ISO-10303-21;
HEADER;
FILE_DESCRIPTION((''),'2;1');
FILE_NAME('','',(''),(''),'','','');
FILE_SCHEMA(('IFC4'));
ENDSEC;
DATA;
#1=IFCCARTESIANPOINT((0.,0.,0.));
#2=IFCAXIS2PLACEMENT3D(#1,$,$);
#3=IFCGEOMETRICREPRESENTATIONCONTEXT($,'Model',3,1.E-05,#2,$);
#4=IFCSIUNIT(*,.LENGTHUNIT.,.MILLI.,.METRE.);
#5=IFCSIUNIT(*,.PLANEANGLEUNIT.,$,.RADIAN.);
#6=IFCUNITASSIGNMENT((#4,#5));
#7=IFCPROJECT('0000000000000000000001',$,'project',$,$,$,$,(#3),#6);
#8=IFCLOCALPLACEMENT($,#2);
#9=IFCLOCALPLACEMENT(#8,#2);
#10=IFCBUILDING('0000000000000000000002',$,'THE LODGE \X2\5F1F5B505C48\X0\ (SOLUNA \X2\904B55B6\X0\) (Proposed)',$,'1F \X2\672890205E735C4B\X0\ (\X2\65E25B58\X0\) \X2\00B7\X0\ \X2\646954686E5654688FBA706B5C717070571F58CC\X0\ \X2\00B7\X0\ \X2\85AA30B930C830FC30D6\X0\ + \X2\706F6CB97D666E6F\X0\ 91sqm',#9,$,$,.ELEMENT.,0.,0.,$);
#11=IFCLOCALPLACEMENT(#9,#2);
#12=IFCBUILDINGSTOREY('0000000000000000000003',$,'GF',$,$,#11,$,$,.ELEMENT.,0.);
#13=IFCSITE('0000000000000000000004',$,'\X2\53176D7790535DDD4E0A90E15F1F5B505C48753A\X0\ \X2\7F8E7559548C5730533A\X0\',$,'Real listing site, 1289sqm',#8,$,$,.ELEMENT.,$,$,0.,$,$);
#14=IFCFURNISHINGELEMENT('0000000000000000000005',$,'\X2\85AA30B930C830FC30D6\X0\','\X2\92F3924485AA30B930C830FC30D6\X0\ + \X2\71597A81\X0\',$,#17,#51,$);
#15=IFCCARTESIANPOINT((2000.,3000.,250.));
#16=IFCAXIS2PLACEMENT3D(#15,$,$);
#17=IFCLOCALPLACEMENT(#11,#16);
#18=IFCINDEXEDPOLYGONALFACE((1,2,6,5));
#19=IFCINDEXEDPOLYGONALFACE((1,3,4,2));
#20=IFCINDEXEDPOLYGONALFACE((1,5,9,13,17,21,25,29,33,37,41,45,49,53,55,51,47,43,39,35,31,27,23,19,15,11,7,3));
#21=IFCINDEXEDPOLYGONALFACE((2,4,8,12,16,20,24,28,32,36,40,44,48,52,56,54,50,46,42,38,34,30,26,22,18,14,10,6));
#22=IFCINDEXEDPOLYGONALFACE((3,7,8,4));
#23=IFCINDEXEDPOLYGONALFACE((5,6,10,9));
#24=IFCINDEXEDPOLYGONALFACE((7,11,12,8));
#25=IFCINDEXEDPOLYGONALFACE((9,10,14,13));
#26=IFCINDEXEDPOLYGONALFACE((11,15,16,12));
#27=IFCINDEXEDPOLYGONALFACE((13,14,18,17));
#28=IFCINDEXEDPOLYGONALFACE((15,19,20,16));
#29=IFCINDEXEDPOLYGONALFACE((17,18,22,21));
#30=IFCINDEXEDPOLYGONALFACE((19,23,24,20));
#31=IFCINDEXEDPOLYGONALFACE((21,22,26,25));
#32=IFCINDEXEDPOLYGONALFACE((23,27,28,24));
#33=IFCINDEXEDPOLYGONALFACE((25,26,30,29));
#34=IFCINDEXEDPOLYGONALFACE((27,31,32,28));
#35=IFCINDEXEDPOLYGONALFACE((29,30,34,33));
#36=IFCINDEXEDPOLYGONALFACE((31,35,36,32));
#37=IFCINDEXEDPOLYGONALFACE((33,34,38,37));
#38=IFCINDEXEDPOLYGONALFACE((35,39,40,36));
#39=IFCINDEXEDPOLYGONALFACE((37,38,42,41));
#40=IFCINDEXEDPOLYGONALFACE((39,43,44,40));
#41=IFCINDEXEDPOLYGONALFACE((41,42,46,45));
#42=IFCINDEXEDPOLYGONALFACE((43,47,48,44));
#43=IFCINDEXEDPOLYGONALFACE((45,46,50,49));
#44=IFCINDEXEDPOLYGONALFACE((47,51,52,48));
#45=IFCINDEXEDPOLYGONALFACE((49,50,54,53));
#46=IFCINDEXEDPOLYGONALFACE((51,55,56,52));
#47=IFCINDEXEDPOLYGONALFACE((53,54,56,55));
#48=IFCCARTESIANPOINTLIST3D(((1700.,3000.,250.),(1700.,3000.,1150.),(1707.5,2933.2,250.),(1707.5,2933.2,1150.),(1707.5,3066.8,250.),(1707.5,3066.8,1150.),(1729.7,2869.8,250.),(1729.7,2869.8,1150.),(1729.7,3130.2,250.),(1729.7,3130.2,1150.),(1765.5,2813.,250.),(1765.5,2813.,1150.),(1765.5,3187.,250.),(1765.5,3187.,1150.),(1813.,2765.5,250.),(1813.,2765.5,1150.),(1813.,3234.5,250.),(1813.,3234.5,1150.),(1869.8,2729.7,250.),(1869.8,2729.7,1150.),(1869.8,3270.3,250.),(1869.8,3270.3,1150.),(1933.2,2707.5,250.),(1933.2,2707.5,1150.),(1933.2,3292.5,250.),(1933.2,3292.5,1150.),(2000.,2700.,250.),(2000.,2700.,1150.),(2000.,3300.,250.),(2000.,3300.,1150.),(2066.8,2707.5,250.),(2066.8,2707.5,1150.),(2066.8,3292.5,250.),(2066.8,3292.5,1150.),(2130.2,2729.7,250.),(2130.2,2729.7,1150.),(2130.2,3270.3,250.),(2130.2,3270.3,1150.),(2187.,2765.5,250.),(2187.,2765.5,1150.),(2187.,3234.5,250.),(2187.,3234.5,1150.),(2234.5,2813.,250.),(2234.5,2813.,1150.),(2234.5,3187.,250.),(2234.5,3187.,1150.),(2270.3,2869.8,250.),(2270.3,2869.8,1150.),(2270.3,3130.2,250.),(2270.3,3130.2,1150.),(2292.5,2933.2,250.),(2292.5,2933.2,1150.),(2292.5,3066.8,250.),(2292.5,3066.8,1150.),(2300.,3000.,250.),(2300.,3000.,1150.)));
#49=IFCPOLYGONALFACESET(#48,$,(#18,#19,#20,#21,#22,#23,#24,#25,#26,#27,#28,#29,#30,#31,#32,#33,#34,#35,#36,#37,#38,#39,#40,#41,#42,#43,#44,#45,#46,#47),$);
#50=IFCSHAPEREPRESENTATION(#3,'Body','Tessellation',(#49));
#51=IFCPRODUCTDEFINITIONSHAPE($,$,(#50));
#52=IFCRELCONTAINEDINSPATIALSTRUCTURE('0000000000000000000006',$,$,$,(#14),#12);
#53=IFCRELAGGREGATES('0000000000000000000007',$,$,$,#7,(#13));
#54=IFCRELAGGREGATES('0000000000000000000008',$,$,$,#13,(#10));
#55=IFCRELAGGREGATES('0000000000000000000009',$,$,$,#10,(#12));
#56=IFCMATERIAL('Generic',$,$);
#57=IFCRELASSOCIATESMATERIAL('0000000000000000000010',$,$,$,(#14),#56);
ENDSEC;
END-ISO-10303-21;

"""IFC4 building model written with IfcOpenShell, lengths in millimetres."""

from ifc_helpers import new_model, si_unit, frame, origin, origin_2d, place, context, project, spatial, circle, extrude, material, element, save


model = new_model("IFC4")

# Units and contexts
model_context = context("Model", 3, precision=1e-05, world=origin())
ifc_project = project(units=[si_unit("LENGTHUNIT", "METRE", prefix="MILLI"), si_unit("PLANEANGLEUNIT", "RADIAN")], contexts=[model_context])

# Site, building, storey
site_placement = place(None, origin())
site = spatial("IfcSite", under=ifc_project, at=site_placement, Name="北海道川上郡弟子屈町 美留和地区", ObjectType="Real listing site, 1289sqm", CompositionType="ELEMENT", RefElevation=0.0)
building_placement = place(site_placement, origin())
building = spatial("IfcBuilding", under=site, at=building_placement, Name="THE LODGE 弟子屈 (SOLUNA 運営) (Proposed)", ObjectType="1F 木造平屋 (既存) · 摩周湖周辺火山灰土壌 · 薪ストーブ + 灯油給湯 91sqm", CompositionType="ELEMENT", ElevationOfRefHeight=0.0, ElevationOfTerrain=0.0)
storey_placement = place(building_placement, origin())
storey = spatial("IfcBuildingStorey", under=building, at=storey_placement, Name="GF", CompositionType="ELEMENT", Elevation=0.0)

# Shared definitions
ifc_material_1 = material(Name="Generic")

# Furnishing element
furnishing_placement = place(storey_placement, frame((2000.0, 3000.0, 250.0)))
element("IfcFurnishingElement", 1, at=furnishing_placement, inside=storey, material=ifc_material_1, Name="薪ストーブ", Description="鋳鉄薪ストーブ + 煙突", context=model_context, shape_type="SweptSolid", body=[
    extrude(circle(Radius=300.0, at=origin_2d()), frame((2000.0, 3000.0, 250.0)), (0.0, 0.0, 1.0), 900.0),
])

save(model, "model.ifc")
